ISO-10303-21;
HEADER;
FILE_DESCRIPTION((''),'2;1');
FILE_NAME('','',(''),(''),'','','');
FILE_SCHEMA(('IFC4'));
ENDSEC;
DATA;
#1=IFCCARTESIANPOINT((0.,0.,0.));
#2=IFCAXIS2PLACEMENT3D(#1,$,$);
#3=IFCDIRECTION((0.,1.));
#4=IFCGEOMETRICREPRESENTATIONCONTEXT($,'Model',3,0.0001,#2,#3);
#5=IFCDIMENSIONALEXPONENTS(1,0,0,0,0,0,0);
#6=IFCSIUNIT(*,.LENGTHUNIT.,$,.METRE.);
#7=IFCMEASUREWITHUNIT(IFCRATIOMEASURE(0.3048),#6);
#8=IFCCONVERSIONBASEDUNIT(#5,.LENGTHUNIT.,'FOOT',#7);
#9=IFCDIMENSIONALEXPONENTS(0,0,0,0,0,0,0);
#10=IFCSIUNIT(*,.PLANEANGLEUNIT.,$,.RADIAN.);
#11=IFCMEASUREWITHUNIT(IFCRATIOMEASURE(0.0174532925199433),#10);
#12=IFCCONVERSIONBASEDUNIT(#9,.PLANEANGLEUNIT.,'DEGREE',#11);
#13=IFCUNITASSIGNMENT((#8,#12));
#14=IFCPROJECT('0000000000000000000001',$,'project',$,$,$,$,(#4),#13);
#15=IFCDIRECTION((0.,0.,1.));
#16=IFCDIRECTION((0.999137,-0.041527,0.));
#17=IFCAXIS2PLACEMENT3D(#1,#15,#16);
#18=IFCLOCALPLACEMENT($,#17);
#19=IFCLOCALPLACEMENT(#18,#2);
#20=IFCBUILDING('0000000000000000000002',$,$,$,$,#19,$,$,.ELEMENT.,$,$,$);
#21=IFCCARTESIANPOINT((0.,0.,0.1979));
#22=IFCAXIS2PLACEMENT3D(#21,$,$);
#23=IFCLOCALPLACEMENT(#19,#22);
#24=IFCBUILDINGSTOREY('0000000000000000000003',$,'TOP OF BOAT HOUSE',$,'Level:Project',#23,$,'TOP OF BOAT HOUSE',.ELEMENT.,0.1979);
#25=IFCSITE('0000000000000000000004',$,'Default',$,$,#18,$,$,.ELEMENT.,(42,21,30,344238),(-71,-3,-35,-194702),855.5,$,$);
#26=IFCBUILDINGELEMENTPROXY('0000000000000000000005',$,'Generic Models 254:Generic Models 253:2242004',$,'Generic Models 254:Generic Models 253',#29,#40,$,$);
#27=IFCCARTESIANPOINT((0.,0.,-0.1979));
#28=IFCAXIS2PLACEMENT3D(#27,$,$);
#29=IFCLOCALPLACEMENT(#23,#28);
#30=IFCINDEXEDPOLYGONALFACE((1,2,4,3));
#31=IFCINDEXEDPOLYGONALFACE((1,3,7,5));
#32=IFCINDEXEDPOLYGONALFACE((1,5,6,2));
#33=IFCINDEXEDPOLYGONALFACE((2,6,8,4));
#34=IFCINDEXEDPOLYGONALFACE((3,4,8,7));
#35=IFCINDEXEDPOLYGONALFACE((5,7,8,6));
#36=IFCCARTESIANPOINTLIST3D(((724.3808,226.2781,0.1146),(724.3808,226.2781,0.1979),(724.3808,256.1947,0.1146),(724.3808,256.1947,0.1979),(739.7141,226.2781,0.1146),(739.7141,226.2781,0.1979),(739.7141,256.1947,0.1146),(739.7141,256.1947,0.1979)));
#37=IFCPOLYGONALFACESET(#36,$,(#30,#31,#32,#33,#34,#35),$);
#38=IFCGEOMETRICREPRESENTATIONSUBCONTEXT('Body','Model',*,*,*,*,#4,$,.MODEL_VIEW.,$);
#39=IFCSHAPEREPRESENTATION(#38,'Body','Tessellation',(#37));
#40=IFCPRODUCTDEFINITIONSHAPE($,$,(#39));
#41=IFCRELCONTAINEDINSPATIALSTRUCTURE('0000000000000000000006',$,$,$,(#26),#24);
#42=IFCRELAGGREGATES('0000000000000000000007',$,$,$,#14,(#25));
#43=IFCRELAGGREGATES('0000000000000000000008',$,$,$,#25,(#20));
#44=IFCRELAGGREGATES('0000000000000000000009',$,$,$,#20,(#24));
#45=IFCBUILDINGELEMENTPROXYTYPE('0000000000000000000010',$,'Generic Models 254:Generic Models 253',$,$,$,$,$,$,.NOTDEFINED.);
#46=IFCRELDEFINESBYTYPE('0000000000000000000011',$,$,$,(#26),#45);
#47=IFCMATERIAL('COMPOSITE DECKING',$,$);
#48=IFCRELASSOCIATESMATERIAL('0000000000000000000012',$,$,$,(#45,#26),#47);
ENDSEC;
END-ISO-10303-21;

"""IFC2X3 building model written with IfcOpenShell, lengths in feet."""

from ifc_helpers import new_model, entity, si_unit, converted_unit, direction, frame, frame_2d, origin, place, context, subcontext, project, spatial, rectangle, extrude, source, transform, mapped, material, type_object, type_shapes, element, save


model = new_model("IFC2X3")

# Units and contexts
model_context = context("Model", 3, precision=0.0001, world=origin(), true_north=direction((0.0, 1.0)))
body_context = subcontext(model_context, "Body", "Model", "MODEL_VIEW")
ifc_project = project(units=[converted_unit("LENGTHUNIT", "FOOT", entity("IfcRatioMeasure", 0.3048), si_unit("LENGTHUNIT", "METRE"), dimensions=[1, 0, 0, 0, 0, 0, 0]), converted_unit("PLANEANGLEUNIT", "DEGREE", entity("IfcRatioMeasure", 0.0174532925199433), si_unit("PLANEANGLEUNIT", "RADIAN"), dimensions=[0, 0, 0, 0, 0, 0, 0])], contexts=[model_context])

# Site, building, storey
site_placement = place(None, frame((0.0, 0.0, 0.0), z_axis=(0.0, 0.0, 1.0), x_axis=(0.999137, -0.041527, 0.0)))
site = spatial("IfcSite", under=ifc_project, at=site_placement, Name="Default", CompositionType="ELEMENT", RefLatitude=(42, 21, 30, 344238), RefLongitude=(-71, -3, -35, -194702), RefElevation=855.5)
building_placement = place(site_placement, origin())
building = spatial("IfcBuilding", under=site, at=building_placement, CompositionType="ELEMENT")
storey_placement = place(building_placement, frame((0.0, 0.0, 0.1979)))
storey = spatial("IfcBuildingStorey", under=building, at=storey_placement, Name="TOP OF BOAT HOUSE", ObjectType="Level:Project", LongName="TOP OF BOAT HOUSE", CompositionType="ELEMENT", Elevation=0.1979)

# Building element proxy
ifc_material_1 = material(Name="COMPOSITE DECKING")
building_element_proxy_type_1 = type_object("IfcBuildingElementProxyType", Name="Generic Models 254:Generic Models 253", PredefinedType="NOTDEFINED", material=ifc_material_1)
shared_shape_1 = source(origin(), body_context, "Body", "SweptSolid", [
    extrude(rectangle(XDim=29.9167, YDim=15.3333, at=frame_2d((0.0, 0.0), x_axis=(1.0, 0.0))), frame((732.0474, 241.2364, 0.1146), z_axis=(0.0, 0.0, 1.0), x_axis=(0.0, -1.0, 0.0)), (0.0, 0.0, 1.0), 0.0833),
])
type_shapes(building_element_proxy_type_1, [shared_shape_1])
proxy_placement = place(storey_placement, frame((0.0, 0.0, -0.1979)))
element("IfcBuildingElementProxy", 1, at=proxy_placement, inside=storey, type_object=building_element_proxy_type_1, material=ifc_material_1, Name="Generic Models 254:Generic Models 253:2242004", ObjectType="Generic Models 254:Generic Models 253", context=body_context, shape_type="MappedRepresentation", body=[
    mapped(shared_shape_1, transform((0.0, 0.0, 0.0), scale=1.0)),
])

save(model, "model.ifc")
